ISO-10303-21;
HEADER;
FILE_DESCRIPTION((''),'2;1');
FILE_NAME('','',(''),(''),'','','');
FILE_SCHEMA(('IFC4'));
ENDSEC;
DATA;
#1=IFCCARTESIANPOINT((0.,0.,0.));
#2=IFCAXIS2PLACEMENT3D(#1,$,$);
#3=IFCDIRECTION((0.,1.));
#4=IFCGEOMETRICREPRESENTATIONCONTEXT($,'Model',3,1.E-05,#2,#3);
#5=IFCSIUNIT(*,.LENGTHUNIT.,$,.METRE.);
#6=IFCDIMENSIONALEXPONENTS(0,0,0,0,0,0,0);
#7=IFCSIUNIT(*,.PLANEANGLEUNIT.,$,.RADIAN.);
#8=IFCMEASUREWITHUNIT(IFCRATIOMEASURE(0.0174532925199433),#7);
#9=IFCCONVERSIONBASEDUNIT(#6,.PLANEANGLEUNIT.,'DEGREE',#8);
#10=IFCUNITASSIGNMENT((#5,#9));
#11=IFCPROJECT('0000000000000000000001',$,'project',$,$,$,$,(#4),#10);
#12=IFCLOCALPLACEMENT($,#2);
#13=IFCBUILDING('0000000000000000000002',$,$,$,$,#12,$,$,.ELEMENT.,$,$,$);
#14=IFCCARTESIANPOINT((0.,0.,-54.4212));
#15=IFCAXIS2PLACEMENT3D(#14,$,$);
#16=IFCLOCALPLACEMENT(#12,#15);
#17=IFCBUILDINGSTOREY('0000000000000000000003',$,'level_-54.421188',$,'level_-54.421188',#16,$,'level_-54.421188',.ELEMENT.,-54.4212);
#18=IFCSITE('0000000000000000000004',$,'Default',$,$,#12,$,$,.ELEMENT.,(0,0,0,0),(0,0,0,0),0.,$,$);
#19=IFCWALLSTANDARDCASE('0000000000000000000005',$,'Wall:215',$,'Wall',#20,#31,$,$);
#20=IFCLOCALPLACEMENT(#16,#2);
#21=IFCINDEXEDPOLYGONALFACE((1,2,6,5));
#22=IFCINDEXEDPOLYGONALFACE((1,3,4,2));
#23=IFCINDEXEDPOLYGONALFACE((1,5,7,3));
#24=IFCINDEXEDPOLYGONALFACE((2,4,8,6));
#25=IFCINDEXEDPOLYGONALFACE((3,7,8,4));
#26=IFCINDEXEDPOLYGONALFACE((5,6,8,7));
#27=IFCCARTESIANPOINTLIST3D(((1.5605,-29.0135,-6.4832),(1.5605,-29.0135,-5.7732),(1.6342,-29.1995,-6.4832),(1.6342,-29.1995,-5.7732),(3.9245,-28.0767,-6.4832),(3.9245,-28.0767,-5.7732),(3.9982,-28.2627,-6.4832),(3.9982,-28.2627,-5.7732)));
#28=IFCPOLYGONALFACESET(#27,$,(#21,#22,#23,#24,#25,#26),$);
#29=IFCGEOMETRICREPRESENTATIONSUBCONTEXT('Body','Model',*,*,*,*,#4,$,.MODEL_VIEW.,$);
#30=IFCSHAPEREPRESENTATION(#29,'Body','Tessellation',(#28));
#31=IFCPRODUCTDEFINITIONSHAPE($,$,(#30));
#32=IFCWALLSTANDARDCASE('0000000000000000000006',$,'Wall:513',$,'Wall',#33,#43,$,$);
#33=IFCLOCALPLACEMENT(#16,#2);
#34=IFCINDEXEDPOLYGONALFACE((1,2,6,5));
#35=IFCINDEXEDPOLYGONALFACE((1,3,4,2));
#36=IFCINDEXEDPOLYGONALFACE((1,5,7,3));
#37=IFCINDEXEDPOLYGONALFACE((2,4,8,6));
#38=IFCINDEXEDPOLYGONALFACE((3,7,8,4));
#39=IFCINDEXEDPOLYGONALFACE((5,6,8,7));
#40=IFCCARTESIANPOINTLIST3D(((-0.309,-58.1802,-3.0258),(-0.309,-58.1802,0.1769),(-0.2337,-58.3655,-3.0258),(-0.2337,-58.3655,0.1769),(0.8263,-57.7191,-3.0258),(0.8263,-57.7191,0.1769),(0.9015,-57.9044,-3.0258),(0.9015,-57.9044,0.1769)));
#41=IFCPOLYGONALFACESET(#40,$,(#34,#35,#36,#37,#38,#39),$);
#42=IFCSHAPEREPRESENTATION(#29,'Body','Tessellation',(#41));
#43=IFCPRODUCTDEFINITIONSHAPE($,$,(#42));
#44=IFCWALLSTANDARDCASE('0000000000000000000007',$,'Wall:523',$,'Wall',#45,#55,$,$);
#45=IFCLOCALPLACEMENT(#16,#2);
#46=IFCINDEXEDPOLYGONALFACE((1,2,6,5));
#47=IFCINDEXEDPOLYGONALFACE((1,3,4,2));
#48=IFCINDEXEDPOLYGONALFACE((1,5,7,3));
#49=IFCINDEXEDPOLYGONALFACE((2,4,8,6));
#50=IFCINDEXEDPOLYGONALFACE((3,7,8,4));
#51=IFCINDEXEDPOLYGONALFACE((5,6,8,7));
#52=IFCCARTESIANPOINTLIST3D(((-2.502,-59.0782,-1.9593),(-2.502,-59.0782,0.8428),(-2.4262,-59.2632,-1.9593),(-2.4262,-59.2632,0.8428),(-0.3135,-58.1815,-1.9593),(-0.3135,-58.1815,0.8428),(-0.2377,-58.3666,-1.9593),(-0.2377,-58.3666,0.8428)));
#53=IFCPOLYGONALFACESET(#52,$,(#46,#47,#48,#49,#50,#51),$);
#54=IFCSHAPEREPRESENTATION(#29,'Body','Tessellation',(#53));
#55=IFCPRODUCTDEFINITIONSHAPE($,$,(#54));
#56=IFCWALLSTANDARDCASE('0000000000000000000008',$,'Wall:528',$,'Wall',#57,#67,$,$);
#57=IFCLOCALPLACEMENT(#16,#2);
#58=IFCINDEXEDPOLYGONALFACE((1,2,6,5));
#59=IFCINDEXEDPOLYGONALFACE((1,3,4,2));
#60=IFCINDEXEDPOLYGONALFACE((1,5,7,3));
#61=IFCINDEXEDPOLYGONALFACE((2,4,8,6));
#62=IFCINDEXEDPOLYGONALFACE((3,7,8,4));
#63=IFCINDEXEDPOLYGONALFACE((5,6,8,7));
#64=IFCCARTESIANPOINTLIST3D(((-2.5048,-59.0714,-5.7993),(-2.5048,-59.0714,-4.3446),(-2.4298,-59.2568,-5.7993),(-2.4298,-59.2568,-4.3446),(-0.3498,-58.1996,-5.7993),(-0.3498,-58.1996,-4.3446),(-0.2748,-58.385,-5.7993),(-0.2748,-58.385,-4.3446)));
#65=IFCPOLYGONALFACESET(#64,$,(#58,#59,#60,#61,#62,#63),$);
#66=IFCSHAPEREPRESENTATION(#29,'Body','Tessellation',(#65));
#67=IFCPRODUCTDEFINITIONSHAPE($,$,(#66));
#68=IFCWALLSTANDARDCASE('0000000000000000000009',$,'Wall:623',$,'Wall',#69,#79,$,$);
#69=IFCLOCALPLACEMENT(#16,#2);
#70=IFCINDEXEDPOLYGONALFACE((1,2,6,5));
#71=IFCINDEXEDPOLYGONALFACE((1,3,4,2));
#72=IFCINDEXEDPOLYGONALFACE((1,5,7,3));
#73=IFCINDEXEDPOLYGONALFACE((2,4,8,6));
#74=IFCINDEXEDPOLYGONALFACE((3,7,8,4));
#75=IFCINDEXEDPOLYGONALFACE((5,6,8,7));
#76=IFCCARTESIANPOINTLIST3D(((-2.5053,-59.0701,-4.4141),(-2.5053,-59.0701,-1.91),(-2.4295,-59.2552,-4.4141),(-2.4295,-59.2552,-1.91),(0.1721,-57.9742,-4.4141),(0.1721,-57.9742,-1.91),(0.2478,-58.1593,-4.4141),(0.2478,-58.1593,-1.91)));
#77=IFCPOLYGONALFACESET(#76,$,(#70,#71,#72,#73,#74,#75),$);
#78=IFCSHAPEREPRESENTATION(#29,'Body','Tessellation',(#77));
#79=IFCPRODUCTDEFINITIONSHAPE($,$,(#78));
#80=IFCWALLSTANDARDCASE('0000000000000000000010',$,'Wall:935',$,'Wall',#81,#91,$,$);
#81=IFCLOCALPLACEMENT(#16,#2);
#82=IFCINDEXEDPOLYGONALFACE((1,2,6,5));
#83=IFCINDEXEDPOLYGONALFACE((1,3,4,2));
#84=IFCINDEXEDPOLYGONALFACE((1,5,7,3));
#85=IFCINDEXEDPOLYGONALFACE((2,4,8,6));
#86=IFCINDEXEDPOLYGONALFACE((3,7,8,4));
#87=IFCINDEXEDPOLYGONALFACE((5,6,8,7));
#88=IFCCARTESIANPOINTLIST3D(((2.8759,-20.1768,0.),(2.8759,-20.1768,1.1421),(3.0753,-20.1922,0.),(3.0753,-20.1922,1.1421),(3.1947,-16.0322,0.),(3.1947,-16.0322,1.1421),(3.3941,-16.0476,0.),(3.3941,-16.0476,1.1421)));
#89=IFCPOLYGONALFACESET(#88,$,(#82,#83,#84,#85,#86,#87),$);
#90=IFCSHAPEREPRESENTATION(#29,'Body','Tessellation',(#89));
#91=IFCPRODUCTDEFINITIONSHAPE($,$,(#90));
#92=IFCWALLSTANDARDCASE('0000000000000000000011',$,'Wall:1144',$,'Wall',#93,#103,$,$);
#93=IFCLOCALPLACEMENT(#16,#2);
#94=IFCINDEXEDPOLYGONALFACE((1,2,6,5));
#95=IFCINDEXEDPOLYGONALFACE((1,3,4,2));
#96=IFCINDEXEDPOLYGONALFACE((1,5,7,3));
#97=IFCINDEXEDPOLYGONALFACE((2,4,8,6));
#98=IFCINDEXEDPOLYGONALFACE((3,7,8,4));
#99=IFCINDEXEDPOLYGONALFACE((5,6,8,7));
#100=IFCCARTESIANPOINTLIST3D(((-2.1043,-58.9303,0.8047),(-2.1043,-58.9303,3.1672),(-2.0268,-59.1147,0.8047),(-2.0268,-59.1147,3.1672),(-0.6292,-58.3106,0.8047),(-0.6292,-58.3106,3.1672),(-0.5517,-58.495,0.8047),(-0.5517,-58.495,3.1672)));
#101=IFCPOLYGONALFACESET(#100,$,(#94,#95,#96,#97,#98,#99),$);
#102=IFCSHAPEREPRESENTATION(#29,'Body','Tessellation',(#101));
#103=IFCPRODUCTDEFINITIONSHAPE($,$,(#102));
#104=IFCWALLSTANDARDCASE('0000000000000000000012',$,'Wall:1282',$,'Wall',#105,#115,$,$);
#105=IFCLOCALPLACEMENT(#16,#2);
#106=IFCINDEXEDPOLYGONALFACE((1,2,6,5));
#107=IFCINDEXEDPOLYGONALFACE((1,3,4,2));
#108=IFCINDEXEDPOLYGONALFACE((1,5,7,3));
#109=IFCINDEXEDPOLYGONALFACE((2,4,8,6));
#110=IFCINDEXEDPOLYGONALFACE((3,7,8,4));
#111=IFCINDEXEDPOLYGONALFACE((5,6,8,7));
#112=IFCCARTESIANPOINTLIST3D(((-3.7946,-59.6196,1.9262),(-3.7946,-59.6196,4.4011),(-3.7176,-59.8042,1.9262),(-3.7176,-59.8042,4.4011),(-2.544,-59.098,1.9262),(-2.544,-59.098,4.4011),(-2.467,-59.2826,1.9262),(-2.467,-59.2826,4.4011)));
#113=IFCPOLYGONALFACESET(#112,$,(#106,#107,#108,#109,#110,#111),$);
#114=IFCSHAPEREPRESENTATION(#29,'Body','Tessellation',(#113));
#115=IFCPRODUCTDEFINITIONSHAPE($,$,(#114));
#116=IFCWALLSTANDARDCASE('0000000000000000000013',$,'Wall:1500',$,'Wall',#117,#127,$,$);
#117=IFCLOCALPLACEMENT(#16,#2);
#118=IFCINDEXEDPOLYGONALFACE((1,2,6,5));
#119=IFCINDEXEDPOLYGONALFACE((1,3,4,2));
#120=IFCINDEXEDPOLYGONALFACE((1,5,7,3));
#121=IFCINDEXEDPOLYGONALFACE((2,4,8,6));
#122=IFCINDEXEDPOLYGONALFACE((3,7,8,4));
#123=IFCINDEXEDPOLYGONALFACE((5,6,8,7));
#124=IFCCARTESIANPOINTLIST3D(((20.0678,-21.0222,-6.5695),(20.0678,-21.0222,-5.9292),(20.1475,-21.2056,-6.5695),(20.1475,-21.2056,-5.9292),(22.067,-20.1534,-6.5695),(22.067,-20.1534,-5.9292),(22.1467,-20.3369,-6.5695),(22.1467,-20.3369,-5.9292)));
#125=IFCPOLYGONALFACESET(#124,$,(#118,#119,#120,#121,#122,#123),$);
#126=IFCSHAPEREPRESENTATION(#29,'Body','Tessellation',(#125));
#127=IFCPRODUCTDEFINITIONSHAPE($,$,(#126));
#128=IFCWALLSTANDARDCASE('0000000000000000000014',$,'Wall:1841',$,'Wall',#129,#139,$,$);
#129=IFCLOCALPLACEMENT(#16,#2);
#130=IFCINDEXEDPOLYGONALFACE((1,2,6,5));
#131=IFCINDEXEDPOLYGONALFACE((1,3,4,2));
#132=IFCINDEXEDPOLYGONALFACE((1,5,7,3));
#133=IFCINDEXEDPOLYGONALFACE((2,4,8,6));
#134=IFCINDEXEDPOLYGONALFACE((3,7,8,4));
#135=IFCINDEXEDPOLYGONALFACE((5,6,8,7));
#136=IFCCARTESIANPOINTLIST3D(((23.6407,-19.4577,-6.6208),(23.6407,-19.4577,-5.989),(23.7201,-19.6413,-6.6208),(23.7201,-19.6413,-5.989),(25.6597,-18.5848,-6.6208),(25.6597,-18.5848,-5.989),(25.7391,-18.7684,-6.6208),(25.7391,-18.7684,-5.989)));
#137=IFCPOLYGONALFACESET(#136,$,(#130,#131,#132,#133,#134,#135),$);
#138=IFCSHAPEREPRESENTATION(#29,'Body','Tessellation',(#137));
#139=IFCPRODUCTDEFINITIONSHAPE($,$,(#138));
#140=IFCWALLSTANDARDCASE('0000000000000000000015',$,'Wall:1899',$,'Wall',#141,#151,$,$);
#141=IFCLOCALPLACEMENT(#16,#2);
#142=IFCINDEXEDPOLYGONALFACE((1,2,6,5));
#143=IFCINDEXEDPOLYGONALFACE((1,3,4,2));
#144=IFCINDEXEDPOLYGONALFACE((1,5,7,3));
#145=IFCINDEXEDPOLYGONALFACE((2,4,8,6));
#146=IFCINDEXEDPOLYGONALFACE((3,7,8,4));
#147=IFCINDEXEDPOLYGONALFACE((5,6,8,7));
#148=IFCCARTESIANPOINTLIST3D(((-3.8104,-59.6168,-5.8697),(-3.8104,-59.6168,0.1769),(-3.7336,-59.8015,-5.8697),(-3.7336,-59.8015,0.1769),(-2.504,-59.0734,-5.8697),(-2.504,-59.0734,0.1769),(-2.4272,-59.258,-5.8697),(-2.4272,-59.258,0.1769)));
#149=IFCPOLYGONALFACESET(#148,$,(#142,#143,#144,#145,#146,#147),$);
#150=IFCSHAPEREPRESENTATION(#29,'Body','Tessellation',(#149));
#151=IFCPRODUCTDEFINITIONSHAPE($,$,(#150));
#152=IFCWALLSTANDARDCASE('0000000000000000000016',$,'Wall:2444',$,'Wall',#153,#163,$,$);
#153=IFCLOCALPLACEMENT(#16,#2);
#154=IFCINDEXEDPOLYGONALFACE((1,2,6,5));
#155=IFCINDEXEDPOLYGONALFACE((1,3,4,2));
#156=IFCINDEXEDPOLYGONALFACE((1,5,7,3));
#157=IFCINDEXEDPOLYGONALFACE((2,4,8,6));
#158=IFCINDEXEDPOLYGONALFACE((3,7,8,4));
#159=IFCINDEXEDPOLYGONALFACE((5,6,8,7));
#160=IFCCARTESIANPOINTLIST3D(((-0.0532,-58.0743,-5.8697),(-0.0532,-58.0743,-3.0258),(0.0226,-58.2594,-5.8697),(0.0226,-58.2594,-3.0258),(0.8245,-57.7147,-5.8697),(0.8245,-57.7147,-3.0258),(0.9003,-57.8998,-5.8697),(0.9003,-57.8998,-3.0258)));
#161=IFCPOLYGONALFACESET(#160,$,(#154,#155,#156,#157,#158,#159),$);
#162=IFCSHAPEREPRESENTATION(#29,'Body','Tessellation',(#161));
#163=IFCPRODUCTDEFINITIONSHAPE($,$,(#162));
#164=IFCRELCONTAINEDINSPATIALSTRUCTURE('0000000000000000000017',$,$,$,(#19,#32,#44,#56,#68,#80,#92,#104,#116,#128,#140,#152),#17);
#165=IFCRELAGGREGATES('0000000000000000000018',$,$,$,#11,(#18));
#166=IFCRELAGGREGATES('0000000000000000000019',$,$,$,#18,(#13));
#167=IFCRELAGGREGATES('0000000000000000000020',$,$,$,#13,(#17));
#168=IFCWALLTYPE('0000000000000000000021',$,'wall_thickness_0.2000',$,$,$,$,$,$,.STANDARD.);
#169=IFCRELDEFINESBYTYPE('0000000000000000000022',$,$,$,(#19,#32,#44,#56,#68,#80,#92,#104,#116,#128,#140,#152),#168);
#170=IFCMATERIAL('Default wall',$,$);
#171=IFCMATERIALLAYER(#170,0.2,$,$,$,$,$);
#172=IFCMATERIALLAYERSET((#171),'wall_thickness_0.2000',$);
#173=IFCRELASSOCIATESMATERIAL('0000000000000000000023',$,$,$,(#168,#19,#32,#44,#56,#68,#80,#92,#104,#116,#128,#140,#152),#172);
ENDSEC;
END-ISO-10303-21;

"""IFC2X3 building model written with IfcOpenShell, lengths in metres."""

from ifc_helpers import new_model, entity, si_unit, converted_unit, direction, frame, origin, place, context, subcontext, project, spatial, polyline, outline, extrude, material, layer, layer_set, layer_usage, type_object, element, save


model = new_model("IFC2X3")

# Units and contexts
model_context = context("Model", 3, precision=1e-05, world=origin(), true_north=direction((0.0, 1.0)))
body_context = subcontext(model_context, "Body", "Model", "MODEL_VIEW")
ifc_project = project(units=[si_unit("LENGTHUNIT", "METRE"), converted_unit("PLANEANGLEUNIT", "DEGREE", entity("IfcRatioMeasure", 0.0174532925199433), si_unit("PLANEANGLEUNIT", "RADIAN"), dimensions=[0, 0, 0, 0, 0, 0, 0])], contexts=[model_context])

# Site, building, storey
placement_1 = place(None, origin())
site = spatial("IfcSite", under=ifc_project, at=placement_1, Name="Default", CompositionType="ELEMENT", RefLatitude=(0, 0, 0, 0), RefLongitude=(0, 0, 0, 0), RefElevation=0.0)
building = spatial("IfcBuilding", under=site, at=placement_1, CompositionType="ELEMENT")
storey_placement = place(placement_1, frame((0.0, 0.0, -54.4212)))
storey = spatial("IfcBuildingStorey", under=building, at=storey_placement, Name="level_-54.421188", ObjectType="level_-54.421188", LongName="level_-54.421188", CompositionType="ELEMENT", Elevation=-54.4212)

# Walls
ifc_material_1 = material(Name="Default wall")
ifc_layer = layer(ifc_material_1, 0.2)
ifc_layer_set = layer_set([ifc_layer], Name="wall_thickness_0.2000")
ifc_layer_usage = layer_usage(ifc_layer_set, "AXIS2", "POSITIVE", -0.1)
wall_type = type_object("IfcWallType", Name="wall_thickness_0.2000", PredefinedType="STANDARD", material=ifc_layer_set)
placement_2 = place(placement_1, frame((0.0, 0.0, -60.9044)))
wall_1_placement = place(placement_2, frame((1.5973, -29.1065, 0.0), z_axis=(0.0, 0.0, 1.0), x_axis=(0.929665, 0.368406, 0.0)))
element("IfcWallStandardCase", 1, at=wall_1_placement, inside=storey, type_object=wall_type, material=ifc_layer_usage, Name="Wall:215", ObjectType="Wall", context=body_context, shape_type="SweptSolid", body=[
    extrude(outline(polyline([(2.5429, -0.1), (2.5429, 0.1), (0.0, 0.1), (0.0, -0.1), (2.5429, -0.1)])), origin(), (0.0, 0.0, 1.0), 0.7101),
])
placement_3 = place(placement_1, frame((0.0, 0.0, -57.447)))
wall_2_placement = place(placement_3, frame((0.8639, -57.8118, 0.0), z_axis=(0.0, 0.0, 1.0), x_axis=(-0.926491, -0.376316, 0.0)))
element("IfcWallStandardCase", 2, at=wall_2_placement, inside=storey, type_object=wall_type, material=ifc_layer_usage, Name="Wall:513", ObjectType="Wall", context=body_context, shape_type="SweptSolid", body=[
    extrude(outline(polyline([(1.2253, -0.1), (1.2253, 0.1), (0.0, 0.1), (0.0, -0.1), (1.2253, -0.1)])), origin(), (0.0, 0.0, 1.0), 3.2027),
])
placement_4 = place(placement_1, frame((0.0, 0.0, -56.3805)))
wall_3_placement = place(placement_4, frame((-0.2756, -58.274, 0.0), z_axis=(0.0, 0.0, 1.0), x_axis=(-0.925339, -0.379141, 0.0)))
element("IfcWallStandardCase", 3, at=wall_3_placement, inside=storey, type_object=wall_type, material=ifc_layer_usage, Name="Wall:523", ObjectType="Wall", context=body_context, shape_type="SweptSolid", body=[
    extrude(outline(polyline([(2.365, -0.1), (2.365, 0.1), (0.0, 0.1), (0.0, -0.1), (2.365, -0.1)])), origin(), (0.0, 0.0, 1.0), 2.8022),
])
placement_5 = place(placement_1, frame((0.0, 0.0, -60.2205)))
wall_4_placement = place(placement_5, frame((-2.4673, -59.1641, 0.0), z_axis=(0.0, 0.0, 1.0), x_axis=(0.927015, 0.375023, 0.0)))
element("IfcWallStandardCase", 4, at=wall_4_placement, inside=storey, type_object=wall_type, material=ifc_layer_usage, Name="Wall:528", ObjectType="Wall", context=body_context, shape_type="SweptSolid", body=[
    extrude(outline(polyline([(2.3246, -0.1), (2.3246, 0.1), (0.0, 0.1), (0.0, -0.1), (2.3246, -0.1)])), origin(), (0.0, 0.0, 1.0), 1.4547),
])
placement_6 = place(placement_1, frame((0.0, 0.0, -58.8353)))
wall_5_placement = place(placement_6, frame((0.2099, -58.0667, 0.0), z_axis=(0.0, 0.0, 1.0), x_axis=(-0.925472, -0.378817, 0.0)))
element("IfcWallStandardCase", 5, at=wall_5_placement, inside=storey, type_object=wall_type, material=ifc_layer_usage, Name="Wall:623", ObjectType="Wall", context=body_context, shape_type="SweptSolid", body=[
    extrude(outline(polyline([(2.893, -0.1), (2.893, 0.1), (0.0, 0.1), (0.0, -0.1), (2.893, -0.1)])), origin(), (0.0, 0.0, 1.0), 2.5041),
])
wall_6_placement = place(storey_placement, frame((2.9756, -20.1845, 0.0), z_axis=(0.0, 0.0, 1.0), x_axis=(0.076673, 0.997056, 0.0)))
element("IfcWallStandardCase", 6, at=wall_6_placement, inside=storey, type_object=wall_type, material=ifc_layer_usage, Name="Wall:935", ObjectType="Wall", context=body_context, shape_type="SweptSolid", body=[
    extrude(outline(polyline([(4.1568, -0.1), (4.1568, 0.1), (0.0, 0.1), (0.0, -0.1), (4.1568, -0.1)])), origin(), (0.0, 0.0, 1.0), 1.1421),
])
placement_7 = place(placement_1, frame((0.0, 0.0, -53.6165)))
wall_7_placement = place(placement_7, frame((-0.5905, -58.4028, 0.0), z_axis=(0.0, 0.0, 1.0), x_axis=(-0.921948, -0.387313, 0.0)))
element("IfcWallStandardCase", 7, at=wall_7_placement, inside=storey, type_object=wall_type, material=ifc_layer_usage, Name="Wall:1144", ObjectType="Wall", context=body_context, shape_type="SweptSolid", body=[
    extrude(outline(polyline([(1.6, -0.1), (1.6, 0.1), (0.0, 0.1), (0.0, -0.1), (1.6, -0.1)])), origin(), (0.0, 0.0, 1.0), 2.3625),
])
placement_8 = place(placement_1, frame((0.0, 0.0, -52.495)))
wall_8_placement = place(placement_8, frame((-3.7561, -59.7119, 0.0), z_axis=(0.0, 0.0, 1.0), x_axis=(0.922945, 0.384932, 0.0)))
element("IfcWallStandardCase", 8, at=wall_8_placement, inside=storey, type_object=wall_type, material=ifc_layer_usage, Name="Wall:1282", ObjectType="Wall", context=body_context, shape_type="SweptSolid", body=[
    extrude(outline(polyline([(1.355, -0.1), (1.355, 0.1), (0.0, 0.1), (0.0, -0.1), (1.355, -0.1)])), origin(), (0.0, 0.0, 1.0), 2.4749),
])
placement_9 = place(placement_1, frame((0.0, 0.0, -60.9907)))
wall_9_placement = place(placement_9, frame((20.1077, -21.1139, 0.0), z_axis=(0.0, 0.0, 1.0), x_axis=(0.917143, 0.398559, 0.0)))
element("IfcWallStandardCase", 9, at=wall_9_placement, inside=storey, type_object=wall_type, material=ifc_layer_usage, Name="Wall:1500", ObjectType="Wall", context=body_context, shape_type="SweptSolid", body=[
    extrude(outline(polyline([(2.1798, -0.1), (2.1798, 0.1), (0.0, 0.1), (0.0, -0.1), (2.1798, -0.1)])), origin(), (0.0, 0.0, 1.0), 0.6403),
])

# Walls
placement_10 = place(placement_1, frame((0.0, 0.0, -61.042)))
wall_10_placement = place(placement_10, frame((23.6804, -19.5495, 0.0), z_axis=(0.0, 0.0, 1.0), x_axis=(0.917895, 0.396824, 0.0)))
element("IfcWallStandardCase", 10, at=wall_10_placement, inside=storey, type_object=wall_type, material=ifc_layer_usage, Name="Wall:1841", ObjectType="Wall", context=body_context, shape_type="SweptSolid", body=[
    extrude(outline(polyline([(2.1996, -0.1), (2.1996, 0.1), (0.0, 0.1), (0.0, -0.1), (2.1996, -0.1)])), origin(), (0.0, 0.0, 1.0), 0.6319),
])
placement_11 = place(placement_1, frame((0.0, 0.0, -60.2909)))
wall_11_placement = place(placement_11, frame((-2.4656, -59.1657, 0.0), z_axis=(0.0, 0.0, 1.0), x_axis=(-0.923303, -0.384071, 0.0)))
element("IfcWallStandardCase", 11, at=wall_11_placement, inside=storey, type_object=wall_type, material=ifc_layer_usage, Name="Wall:1899", ObjectType="Wall", context=body_context, shape_type="SweptSolid", body=[
    extrude(outline(polyline([(1.415, -0.1), (1.415, 0.1), (0.0, 0.1), (0.0, -0.1), (1.415, -0.1)])), origin(), (0.0, 0.0, 1.0), 6.0466),
])
placement_12 = place(placement_1, frame((0.0, 0.0, -60.2909)))
wall_12_placement = place(placement_12, frame((0.8624, -57.8073, 0.0), z_axis=(0.0, 0.0, 1.0), x_axis=(-0.925361, -0.379087, 0.0)))
element("IfcWallStandardCase", 12, at=wall_12_placement, inside=storey, type_object=wall_type, material=ifc_layer_usage, Name="Wall:2444", ObjectType="Wall", context=body_context, shape_type="SweptSolid", body=[
    extrude(outline(polyline([(0.9485, -0.1), (0.9485, 0.1), (0.0, 0.1), (0.0, -0.1), (0.9485, -0.1)])), origin(), (0.0, 0.0, 1.0), 2.8439),
])

save(model, "model.ifc")
